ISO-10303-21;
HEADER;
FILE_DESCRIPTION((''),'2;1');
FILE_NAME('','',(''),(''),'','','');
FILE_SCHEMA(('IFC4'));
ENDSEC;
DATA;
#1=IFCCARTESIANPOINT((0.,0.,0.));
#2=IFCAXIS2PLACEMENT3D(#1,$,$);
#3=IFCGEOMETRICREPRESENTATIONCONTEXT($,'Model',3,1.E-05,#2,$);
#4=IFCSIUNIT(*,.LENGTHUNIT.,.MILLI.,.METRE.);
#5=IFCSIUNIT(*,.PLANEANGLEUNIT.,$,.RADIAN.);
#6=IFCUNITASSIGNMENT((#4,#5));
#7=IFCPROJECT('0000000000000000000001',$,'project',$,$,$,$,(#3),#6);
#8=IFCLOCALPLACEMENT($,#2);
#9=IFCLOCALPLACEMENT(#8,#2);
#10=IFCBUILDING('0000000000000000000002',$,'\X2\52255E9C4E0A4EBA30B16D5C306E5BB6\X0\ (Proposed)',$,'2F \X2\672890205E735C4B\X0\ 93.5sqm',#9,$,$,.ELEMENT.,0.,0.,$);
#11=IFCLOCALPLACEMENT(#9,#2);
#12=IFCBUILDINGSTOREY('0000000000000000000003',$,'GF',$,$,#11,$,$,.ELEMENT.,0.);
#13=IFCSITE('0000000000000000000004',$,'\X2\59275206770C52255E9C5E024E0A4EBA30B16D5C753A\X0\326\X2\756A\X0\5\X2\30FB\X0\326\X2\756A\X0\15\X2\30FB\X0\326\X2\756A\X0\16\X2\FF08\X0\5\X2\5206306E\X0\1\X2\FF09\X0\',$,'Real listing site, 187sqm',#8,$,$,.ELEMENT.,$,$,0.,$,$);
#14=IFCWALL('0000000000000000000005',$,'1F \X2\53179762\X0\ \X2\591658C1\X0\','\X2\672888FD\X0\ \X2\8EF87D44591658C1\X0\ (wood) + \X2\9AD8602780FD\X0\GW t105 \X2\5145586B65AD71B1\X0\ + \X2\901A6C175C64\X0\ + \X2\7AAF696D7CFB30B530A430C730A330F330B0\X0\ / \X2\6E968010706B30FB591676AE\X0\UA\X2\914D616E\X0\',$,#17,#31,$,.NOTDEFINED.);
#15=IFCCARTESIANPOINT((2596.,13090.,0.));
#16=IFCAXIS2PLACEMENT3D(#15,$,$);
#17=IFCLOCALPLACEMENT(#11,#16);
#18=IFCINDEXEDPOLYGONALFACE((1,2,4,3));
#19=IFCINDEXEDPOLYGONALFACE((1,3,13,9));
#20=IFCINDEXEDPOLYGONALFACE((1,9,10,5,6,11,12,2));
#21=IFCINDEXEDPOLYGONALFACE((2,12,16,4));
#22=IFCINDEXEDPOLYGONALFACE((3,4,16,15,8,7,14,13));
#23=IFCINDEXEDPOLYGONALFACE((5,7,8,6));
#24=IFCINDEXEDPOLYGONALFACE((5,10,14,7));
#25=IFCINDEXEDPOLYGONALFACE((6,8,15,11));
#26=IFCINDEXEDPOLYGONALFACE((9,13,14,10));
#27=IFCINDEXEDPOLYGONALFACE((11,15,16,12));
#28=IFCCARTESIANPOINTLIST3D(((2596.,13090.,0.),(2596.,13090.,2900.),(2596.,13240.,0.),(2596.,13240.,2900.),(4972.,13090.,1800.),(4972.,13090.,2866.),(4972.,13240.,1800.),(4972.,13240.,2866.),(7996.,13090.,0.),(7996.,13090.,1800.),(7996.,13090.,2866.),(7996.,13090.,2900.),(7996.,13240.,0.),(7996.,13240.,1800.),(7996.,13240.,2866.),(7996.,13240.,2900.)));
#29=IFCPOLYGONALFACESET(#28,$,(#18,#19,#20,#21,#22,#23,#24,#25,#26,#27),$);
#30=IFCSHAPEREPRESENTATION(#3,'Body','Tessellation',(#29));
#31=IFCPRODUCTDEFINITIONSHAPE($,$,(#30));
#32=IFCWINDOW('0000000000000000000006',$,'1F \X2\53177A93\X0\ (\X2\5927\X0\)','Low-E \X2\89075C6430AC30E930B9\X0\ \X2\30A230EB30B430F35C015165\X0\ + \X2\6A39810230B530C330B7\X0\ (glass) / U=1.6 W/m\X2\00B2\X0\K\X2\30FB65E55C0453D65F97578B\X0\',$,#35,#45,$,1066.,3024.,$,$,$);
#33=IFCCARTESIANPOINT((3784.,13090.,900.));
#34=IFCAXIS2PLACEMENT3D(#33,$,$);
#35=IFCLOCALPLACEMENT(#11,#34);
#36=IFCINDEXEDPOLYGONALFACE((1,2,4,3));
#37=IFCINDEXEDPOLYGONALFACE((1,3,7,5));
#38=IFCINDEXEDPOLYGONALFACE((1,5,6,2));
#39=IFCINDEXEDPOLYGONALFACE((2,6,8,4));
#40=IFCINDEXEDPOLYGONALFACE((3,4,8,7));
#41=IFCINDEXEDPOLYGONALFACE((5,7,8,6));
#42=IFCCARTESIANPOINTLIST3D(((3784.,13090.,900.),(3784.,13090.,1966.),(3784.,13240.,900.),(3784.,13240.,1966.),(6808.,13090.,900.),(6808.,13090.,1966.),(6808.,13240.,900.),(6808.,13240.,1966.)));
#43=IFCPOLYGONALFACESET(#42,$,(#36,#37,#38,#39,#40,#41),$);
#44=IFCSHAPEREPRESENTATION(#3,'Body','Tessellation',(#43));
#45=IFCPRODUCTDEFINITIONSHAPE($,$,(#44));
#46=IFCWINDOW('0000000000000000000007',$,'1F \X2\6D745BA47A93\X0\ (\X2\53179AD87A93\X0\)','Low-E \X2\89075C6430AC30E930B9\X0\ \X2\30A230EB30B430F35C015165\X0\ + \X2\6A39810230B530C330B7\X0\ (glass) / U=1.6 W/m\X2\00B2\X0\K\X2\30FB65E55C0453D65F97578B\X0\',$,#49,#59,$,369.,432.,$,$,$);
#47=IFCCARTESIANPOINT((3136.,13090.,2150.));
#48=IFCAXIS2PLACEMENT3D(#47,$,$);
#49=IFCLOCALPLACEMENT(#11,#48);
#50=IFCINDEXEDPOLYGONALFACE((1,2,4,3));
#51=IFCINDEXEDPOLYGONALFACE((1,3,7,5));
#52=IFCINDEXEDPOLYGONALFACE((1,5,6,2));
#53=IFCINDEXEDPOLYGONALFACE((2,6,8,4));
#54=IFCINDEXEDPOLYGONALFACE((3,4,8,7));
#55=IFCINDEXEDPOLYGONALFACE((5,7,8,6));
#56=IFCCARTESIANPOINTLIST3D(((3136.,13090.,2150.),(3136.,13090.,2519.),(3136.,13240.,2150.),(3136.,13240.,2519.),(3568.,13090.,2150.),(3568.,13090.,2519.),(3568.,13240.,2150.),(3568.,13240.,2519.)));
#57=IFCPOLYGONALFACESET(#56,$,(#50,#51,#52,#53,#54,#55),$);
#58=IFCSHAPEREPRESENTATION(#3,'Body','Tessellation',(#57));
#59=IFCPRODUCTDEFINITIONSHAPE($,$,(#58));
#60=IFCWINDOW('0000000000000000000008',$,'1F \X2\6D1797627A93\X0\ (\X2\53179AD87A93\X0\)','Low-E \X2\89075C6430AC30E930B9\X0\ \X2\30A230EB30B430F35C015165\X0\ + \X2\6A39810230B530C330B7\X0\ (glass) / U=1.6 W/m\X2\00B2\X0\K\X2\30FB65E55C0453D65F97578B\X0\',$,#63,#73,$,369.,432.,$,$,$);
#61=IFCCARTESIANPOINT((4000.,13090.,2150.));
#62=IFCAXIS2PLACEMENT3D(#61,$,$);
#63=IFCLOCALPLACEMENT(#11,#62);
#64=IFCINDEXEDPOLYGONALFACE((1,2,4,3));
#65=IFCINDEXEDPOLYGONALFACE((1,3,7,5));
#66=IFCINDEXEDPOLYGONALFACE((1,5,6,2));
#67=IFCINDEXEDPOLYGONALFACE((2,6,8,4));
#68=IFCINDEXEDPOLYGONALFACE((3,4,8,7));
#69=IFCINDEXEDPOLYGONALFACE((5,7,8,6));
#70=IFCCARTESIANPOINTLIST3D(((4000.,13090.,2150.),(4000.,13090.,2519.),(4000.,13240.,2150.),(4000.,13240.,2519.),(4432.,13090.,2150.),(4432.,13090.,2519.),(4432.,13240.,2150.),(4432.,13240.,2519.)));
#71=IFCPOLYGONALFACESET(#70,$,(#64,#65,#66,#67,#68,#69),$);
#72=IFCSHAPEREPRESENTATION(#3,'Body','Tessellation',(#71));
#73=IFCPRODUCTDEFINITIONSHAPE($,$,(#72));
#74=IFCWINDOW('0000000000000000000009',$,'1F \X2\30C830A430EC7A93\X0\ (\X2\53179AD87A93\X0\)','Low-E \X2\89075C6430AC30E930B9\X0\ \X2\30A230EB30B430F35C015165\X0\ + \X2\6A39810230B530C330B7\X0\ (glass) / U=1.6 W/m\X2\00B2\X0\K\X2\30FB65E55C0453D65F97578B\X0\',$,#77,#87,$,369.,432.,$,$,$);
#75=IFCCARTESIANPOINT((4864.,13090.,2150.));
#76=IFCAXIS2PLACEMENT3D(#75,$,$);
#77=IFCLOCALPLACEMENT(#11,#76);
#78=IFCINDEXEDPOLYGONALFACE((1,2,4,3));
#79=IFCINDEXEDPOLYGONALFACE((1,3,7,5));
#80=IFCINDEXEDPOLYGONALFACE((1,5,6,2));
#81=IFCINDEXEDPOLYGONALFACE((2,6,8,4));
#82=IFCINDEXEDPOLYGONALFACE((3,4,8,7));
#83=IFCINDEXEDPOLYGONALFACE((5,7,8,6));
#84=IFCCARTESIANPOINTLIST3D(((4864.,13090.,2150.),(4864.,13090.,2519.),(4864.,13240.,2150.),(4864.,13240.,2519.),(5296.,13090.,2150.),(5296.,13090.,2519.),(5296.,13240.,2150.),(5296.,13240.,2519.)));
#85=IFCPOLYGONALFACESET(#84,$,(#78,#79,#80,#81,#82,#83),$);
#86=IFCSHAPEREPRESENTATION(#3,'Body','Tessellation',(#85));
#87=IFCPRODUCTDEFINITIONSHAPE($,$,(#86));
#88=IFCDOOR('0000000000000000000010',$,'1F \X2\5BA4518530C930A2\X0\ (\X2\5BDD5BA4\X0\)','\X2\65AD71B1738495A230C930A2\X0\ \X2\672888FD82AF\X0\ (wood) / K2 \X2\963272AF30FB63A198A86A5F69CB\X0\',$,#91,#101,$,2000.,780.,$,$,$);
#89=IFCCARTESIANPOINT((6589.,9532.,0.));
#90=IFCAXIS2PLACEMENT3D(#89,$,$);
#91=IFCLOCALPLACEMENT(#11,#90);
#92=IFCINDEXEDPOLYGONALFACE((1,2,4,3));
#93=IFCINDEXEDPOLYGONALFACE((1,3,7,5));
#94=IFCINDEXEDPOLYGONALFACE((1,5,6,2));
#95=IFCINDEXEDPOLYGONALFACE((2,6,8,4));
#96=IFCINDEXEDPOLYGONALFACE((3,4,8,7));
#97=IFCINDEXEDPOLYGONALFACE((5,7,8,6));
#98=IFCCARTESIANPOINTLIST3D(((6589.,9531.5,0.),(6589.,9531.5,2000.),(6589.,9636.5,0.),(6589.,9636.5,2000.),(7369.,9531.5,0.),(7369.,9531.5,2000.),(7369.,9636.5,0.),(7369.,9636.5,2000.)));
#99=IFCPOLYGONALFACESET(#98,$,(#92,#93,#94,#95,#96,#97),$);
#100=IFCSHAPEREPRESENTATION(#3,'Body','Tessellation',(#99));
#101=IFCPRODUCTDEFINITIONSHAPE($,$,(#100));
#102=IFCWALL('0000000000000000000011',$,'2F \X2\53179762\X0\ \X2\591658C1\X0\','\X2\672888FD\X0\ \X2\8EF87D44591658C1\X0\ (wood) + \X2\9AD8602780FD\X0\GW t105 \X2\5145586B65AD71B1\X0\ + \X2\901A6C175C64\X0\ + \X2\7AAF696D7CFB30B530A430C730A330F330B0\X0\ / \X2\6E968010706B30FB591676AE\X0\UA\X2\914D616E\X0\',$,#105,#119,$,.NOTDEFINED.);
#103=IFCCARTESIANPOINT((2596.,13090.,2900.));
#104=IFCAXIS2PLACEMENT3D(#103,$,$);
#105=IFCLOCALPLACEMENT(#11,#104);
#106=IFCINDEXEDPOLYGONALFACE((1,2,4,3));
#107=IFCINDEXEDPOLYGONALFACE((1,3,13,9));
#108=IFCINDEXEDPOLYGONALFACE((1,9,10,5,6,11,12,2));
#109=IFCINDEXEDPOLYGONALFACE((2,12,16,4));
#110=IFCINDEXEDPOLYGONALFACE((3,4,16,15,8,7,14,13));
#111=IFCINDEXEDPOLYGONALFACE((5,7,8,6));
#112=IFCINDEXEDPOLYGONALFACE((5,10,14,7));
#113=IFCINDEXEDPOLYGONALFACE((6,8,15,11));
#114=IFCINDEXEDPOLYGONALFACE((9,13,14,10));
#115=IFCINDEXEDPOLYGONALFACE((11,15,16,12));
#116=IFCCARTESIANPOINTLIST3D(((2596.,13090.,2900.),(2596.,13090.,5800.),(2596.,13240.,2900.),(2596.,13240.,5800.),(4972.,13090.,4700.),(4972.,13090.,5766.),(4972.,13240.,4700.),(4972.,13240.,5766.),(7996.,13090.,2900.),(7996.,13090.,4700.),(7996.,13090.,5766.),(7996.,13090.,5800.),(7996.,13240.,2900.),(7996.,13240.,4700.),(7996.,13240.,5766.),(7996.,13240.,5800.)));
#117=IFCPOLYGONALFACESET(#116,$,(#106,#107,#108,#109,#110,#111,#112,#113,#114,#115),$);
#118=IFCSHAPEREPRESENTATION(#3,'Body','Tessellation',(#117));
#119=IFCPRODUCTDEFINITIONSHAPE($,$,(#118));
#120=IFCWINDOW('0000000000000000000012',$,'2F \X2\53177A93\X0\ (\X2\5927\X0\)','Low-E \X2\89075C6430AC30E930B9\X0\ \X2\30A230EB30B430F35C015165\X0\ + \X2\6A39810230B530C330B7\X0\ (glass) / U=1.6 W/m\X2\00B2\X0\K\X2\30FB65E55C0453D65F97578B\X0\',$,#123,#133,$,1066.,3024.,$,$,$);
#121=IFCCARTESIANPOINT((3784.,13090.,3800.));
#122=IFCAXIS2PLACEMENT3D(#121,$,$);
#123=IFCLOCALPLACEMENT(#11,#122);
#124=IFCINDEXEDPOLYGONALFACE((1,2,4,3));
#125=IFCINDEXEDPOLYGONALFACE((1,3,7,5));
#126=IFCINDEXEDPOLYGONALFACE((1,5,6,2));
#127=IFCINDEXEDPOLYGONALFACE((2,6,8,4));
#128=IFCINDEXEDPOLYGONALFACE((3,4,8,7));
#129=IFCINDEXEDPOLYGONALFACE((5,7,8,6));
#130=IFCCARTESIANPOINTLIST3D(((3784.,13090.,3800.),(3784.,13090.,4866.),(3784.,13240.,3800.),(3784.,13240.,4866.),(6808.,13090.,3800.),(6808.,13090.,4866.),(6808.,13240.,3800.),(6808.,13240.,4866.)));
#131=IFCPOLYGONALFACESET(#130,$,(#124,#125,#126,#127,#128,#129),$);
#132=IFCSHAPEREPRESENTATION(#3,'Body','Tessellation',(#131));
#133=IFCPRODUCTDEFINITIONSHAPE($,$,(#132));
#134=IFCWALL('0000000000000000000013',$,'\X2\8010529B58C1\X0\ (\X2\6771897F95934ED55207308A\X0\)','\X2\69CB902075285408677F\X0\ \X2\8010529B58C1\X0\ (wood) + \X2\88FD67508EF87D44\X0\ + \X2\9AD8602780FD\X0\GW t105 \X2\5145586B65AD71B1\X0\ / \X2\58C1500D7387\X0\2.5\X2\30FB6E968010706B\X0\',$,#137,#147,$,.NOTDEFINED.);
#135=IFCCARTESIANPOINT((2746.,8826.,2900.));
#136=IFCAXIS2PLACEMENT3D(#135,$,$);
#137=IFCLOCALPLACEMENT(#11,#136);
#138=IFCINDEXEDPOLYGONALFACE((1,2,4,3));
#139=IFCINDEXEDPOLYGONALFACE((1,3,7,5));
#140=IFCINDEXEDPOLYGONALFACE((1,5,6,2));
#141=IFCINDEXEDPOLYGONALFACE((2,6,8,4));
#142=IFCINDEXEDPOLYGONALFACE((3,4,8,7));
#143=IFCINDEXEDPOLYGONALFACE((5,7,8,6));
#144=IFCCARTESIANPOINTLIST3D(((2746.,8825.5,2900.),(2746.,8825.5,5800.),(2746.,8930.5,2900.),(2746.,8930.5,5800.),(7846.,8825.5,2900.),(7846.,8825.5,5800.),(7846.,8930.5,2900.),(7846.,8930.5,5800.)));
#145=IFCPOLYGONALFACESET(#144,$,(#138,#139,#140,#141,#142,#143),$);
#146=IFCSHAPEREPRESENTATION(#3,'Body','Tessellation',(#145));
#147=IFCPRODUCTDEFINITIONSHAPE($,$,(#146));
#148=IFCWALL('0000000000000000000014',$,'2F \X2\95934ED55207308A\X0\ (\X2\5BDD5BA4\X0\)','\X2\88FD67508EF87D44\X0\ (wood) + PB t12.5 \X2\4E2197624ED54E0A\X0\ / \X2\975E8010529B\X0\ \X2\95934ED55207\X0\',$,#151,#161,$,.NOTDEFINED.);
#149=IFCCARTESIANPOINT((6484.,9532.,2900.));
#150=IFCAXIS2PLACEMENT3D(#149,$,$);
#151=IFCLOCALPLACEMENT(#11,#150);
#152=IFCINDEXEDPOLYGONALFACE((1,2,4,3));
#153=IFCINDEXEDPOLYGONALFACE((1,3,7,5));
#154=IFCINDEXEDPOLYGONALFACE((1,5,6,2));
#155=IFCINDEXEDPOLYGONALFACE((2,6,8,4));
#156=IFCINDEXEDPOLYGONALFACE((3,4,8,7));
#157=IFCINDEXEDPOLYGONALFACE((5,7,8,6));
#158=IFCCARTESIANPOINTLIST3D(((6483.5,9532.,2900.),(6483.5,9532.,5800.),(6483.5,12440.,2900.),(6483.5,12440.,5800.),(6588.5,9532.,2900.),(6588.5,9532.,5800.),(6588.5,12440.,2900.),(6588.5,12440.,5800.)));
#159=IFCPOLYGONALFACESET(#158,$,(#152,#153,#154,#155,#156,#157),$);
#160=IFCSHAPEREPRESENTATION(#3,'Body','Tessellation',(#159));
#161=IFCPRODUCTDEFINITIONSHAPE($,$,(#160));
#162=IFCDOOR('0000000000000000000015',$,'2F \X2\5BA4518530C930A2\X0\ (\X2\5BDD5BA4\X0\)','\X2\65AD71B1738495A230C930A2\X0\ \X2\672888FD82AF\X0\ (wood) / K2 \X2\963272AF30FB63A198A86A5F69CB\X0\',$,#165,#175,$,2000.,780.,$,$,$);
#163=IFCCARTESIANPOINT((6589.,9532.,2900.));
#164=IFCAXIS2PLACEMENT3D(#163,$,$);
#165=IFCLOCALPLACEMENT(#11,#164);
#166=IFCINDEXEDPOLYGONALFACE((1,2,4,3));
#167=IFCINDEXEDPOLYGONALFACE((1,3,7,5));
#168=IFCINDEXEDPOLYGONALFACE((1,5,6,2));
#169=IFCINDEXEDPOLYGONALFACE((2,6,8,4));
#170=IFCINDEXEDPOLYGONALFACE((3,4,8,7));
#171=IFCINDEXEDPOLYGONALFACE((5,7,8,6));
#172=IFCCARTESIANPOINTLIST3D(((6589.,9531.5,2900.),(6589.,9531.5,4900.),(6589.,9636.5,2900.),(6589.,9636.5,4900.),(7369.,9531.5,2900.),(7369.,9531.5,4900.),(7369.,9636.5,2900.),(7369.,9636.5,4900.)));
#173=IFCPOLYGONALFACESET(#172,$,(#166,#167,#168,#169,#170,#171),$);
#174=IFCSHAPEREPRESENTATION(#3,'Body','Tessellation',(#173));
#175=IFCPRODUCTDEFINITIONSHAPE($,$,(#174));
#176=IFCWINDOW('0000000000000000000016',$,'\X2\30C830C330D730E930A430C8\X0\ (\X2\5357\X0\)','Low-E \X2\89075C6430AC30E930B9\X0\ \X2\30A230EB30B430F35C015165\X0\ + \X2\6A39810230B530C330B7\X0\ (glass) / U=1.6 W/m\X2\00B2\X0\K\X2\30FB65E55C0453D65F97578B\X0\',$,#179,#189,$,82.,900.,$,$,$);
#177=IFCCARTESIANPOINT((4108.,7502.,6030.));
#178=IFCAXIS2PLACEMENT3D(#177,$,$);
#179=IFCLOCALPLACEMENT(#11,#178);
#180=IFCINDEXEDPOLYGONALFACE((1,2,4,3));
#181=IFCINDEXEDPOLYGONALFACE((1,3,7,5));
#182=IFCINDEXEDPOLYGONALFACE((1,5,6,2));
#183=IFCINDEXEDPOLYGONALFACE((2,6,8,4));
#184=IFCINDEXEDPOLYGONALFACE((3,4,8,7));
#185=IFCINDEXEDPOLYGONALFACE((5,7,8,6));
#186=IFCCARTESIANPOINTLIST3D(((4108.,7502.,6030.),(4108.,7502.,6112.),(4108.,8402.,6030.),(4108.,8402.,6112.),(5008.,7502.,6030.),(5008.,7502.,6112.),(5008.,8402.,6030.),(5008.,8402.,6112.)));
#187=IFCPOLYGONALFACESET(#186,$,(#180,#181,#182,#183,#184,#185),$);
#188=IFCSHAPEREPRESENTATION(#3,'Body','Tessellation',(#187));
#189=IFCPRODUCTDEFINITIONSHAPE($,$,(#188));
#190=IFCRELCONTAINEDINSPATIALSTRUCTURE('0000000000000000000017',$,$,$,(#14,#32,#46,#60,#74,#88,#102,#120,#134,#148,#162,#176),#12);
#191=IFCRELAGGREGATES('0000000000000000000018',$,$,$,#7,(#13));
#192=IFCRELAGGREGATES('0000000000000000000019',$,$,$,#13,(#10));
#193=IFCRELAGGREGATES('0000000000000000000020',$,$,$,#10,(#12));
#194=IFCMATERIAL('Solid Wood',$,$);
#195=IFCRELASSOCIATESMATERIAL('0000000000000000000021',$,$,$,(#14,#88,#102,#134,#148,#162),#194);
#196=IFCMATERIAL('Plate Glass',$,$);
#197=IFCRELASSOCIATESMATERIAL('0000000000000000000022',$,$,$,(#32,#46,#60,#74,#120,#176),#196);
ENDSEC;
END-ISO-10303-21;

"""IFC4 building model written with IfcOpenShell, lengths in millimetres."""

from ifc_helpers import new_model, si_unit, frame, frame_2d, origin, place, context, project, spatial, rectangle, extrude, material, element, fill, save


model = new_model("IFC4")

# Units and contexts
model_context = context("Model", 3, precision=1e-05, world=origin())
ifc_project = project(units=[si_unit("LENGTHUNIT", "METRE", prefix="MILLI"), si_unit("PLANEANGLEUNIT", "RADIAN")], contexts=[model_context])

# Site, building, storey
site_placement = place(None, origin())
site = spatial("IfcSite", under=ifc_project, at=site_placement, Name="大分県別府市上人ケ浜町326番5・326番15・326番16（5分の1）", ObjectType="Real listing site, 187sqm", CompositionType="ELEMENT", RefElevation=0.0)
building_placement = place(site_placement, origin())
building = spatial("IfcBuilding", under=site, at=building_placement, Name="別府上人ケ浜の家 (Proposed)", ObjectType="2F 木造平屋 93.5sqm", CompositionType="ELEMENT", ElevationOfRefHeight=0.0, ElevationOfTerrain=0.0)
storey_placement = place(building_placement, origin())
storey = spatial("IfcBuildingStorey", under=building, at=storey_placement, Name="GF", CompositionType="ELEMENT", Elevation=0.0)

# Wall, openings, windows
ifc_material_1 = material(Name="Solid Wood")
wall_1_placement = place(storey_placement, frame((2596.0, 13090.0, 0.0)))
wall_1 = element("IfcWall", 1, at=wall_1_placement, inside=storey, material=ifc_material_1, Name="1F 北面 外壁", Description="木製 軸組外壁 (wood) + 高性能GW t105 充填断熱 + 通気層 + 窯業系サイディング / 準耐火・外皮UA配慮", PredefinedType="NOTDEFINED", context=model_context, shape_type="SweptSolid", body=[
    extrude(rectangle(XDim=5400.0, YDim=150.0, at=frame_2d((2700.0, 75.0))), frame((2596.0, 13090.0, 0.0)), (0.0, 0.0, 1.0), 2900.0),
])
opening_1_placement = place(storey_placement, frame((3784.0, 13090.0, 900.0)))
opening_1 = element("IfcOpeningElement", 2, at=opening_1_placement, cuts=wall_1, PredefinedType="NOTDEFINED", context=model_context, shape_type="SweptSolid", body=[
    extrude(rectangle(XDim=3024.0, YDim=150.0, at=frame_2d((1512.0, 75.0))), frame((3784.0, 13090.0, 900.0)), (0.0, 0.0, 1.0), 1066.0),
])
opening_2_placement = place(storey_placement, frame((3136.0, 13090.0, 2150.0)))
opening_2 = element("IfcOpeningElement", 3, at=opening_2_placement, cuts=wall_1, PredefinedType="NOTDEFINED", context=model_context, shape_type="SweptSolid", body=[
    extrude(rectangle(XDim=432.0, YDim=150.0, at=frame_2d((216.0, 75.0))), frame((3136.0, 13090.0, 2150.0)), (0.0, 0.0, 1.0), 369.0),
])
opening_3_placement = place(storey_placement, frame((4000.0, 13090.0, 2150.0)))
opening_3 = element("IfcOpeningElement", 4, at=opening_3_placement, cuts=wall_1, PredefinedType="NOTDEFINED", context=model_context, shape_type="SweptSolid", body=[
    extrude(rectangle(XDim=432.0, YDim=150.0, at=frame_2d((216.0, 75.0))), frame((4000.0, 13090.0, 2150.0)), (0.0, 0.0, 1.0), 369.0),
])
opening_4_placement = place(storey_placement, frame((4864.0, 13090.0, 2150.0)))
opening_4 = element("IfcOpeningElement", 5, at=opening_4_placement, cuts=wall_1, PredefinedType="NOTDEFINED", context=model_context, shape_type="SweptSolid", body=[
    extrude(rectangle(XDim=432.0, YDim=150.0, at=frame_2d((216.0, 75.0))), frame((4864.0, 13090.0, 2150.0)), (0.0, 0.0, 1.0), 369.0),
])
ifc_material_2 = material(Name="Plate Glass")
window_1_placement = place(storey_placement, frame((3784.0, 13090.0, 900.0)))
window_1 = element("IfcWindow", 6, at=window_1_placement, inside=storey, material=ifc_material_2, Name="1F 北窓 (大)", Description="Low-E 複層ガラス アルゴン封入 + 樹脂サッシ (glass) / U=1.6 W/m²K・日射取得型", OverallHeight=1066.0, OverallWidth=3024.0, context=model_context, shape_type="SweptSolid", body=[
    extrude(rectangle(XDim=3024.0, YDim=150.0, at=frame_2d((1512.0, 75.0))), frame((3784.0, 13090.0, 900.0)), (0.0, 0.0, 1.0), 1066.0),
])
fill(opening_1, window_1)
window_2_placement = place(storey_placement, frame((3136.0, 13090.0, 2150.0)))
window_2 = element("IfcWindow", 7, at=window_2_placement, inside=storey, material=ifc_material_2, Name="1F 浴室窓 (北高窓)", Description="Low-E 複層ガラス アルゴン封入 + 樹脂サッシ (glass) / U=1.6 W/m²K・日射取得型", OverallHeight=369.0, OverallWidth=432.0, context=model_context, shape_type="SweptSolid", body=[
    extrude(rectangle(XDim=432.0, YDim=150.0, at=frame_2d((216.0, 75.0))), frame((3136.0, 13090.0, 2150.0)), (0.0, 0.0, 1.0), 369.0),
])
fill(opening_2, window_2)
window_3_placement = place(storey_placement, frame((4000.0, 13090.0, 2150.0)))
window_3 = element("IfcWindow", 8, at=window_3_placement, inside=storey, material=ifc_material_2, Name="1F 洗面窓 (北高窓)", Description="Low-E 複層ガラス アルゴン封入 + 樹脂サッシ (glass) / U=1.6 W/m²K・日射取得型", OverallHeight=369.0, OverallWidth=432.0, context=model_context, shape_type="SweptSolid", body=[
    extrude(rectangle(XDim=432.0, YDim=150.0, at=frame_2d((216.0, 75.0))), frame((4000.0, 13090.0, 2150.0)), (0.0, 0.0, 1.0), 369.0),
])
fill(opening_3, window_3)
window_4_placement = place(storey_placement, frame((4864.0, 13090.0, 2150.0)))
window_4 = element("IfcWindow", 9, at=window_4_placement, inside=storey, material=ifc_material_2, Name="1F トイレ窓 (北高窓)", Description="Low-E 複層ガラス アルゴン封入 + 樹脂サッシ (glass) / U=1.6 W/m²K・日射取得型", OverallHeight=369.0, OverallWidth=432.0, context=model_context, shape_type="SweptSolid", body=[
    extrude(rectangle(XDim=432.0, YDim=150.0, at=frame_2d((216.0, 75.0))), frame((4864.0, 13090.0, 2150.0)), (0.0, 0.0, 1.0), 369.0),
])
fill(opening_4, window_4)

# Door
door_1_placement = place(storey_placement, frame((6589.0, 9532.0, 0.0)))
element("IfcDoor", 10, at=door_1_placement, inside=storey, material=ifc_material_1, Name="1F 室内ドア (寝室)", Description="断熱玄関ドア 木製芯 (wood) / K2 防犯・採風機構", OverallHeight=2000.0, OverallWidth=780.0, context=model_context, shape_type="SweptSolid", body=[
    extrude(rectangle(XDim=780.0, YDim=105.0, at=frame_2d((390.0, 52.0))), frame((6589.0, 9532.0, 0.0)), (0.0, 0.0, 1.0), 2000.0),
])

# Wall, opening, window
wall_2_placement = place(storey_placement, frame((2596.0, 13090.0, 2900.0)))
wall_2 = element("IfcWall", 11, at=wall_2_placement, inside=storey, material=ifc_material_1, Name="2F 北面 外壁", Description="木製 軸組外壁 (wood) + 高性能GW t105 充填断熱 + 通気層 + 窯業系サイディング / 準耐火・外皮UA配慮", PredefinedType="NOTDEFINED", context=model_context, shape_type="SweptSolid", body=[
    extrude(rectangle(XDim=5400.0, YDim=150.0, at=frame_2d((2700.0, 75.0))), frame((2596.0, 13090.0, 2900.0)), (0.0, 0.0, 1.0), 2900.0),
])
opening_5_placement = place(storey_placement, frame((3784.0, 13090.0, 3800.0)))
opening_5 = element("IfcOpeningElement", 12, at=opening_5_placement, cuts=wall_2, PredefinedType="NOTDEFINED", context=model_context, shape_type="SweptSolid", body=[
    extrude(rectangle(XDim=3024.0, YDim=150.0, at=frame_2d((1512.0, 75.0))), frame((3784.0, 13090.0, 3800.0)), (0.0, 0.0, 1.0), 1066.0),
])
window_5_placement = place(storey_placement, frame((3784.0, 13090.0, 3800.0)))
window_5 = element("IfcWindow", 13, at=window_5_placement, inside=storey, material=ifc_material_2, Name="2F 北窓 (大)", Description="Low-E 複層ガラス アルゴン封入 + 樹脂サッシ (glass) / U=1.6 W/m²K・日射取得型", OverallHeight=1066.0, OverallWidth=3024.0, context=model_context, shape_type="SweptSolid", body=[
    extrude(rectangle(XDim=3024.0, YDim=150.0, at=frame_2d((1512.0, 75.0))), frame((3784.0, 13090.0, 3800.0)), (0.0, 0.0, 1.0), 1066.0),
])
fill(opening_5, window_5)

# Walls
wall_3_placement = place(storey_placement, frame((2746.0, 8826.0, 2900.0)))
element("IfcWall", 14, at=wall_3_placement, inside=storey, material=ifc_material_1, Name="耐力壁 (東西間仕切り)", Description="構造用合板 耐力壁 (wood) + 製材軸組 + 高性能GW t105 充填断熱 / 壁倍率2.5・準耐火", PredefinedType="NOTDEFINED", context=model_context, shape_type="SweptSolid", body=[
    extrude(rectangle(XDim=5100.0, YDim=105.0, at=frame_2d((2550.0, 52.0))), frame((2746.0, 8826.0, 2900.0)), (0.0, 0.0, 1.0), 2900.0),
])
wall_4_placement = place(storey_placement, frame((6484.0, 9532.0, 2900.0)))
element("IfcWall", 15, at=wall_4_placement, inside=storey, material=ifc_material_1, Name="2F 間仕切り (寝室)", Description="製材軸組 (wood) + PB t12.5 両面仕上 / 非耐力 間仕切", PredefinedType="NOTDEFINED", context=model_context, shape_type="SweptSolid", body=[
    extrude(rectangle(XDim=105.0, YDim=2908.0, at=frame_2d((52.0, 1454.0))), frame((6484.0, 9532.0, 2900.0)), (0.0, 0.0, 1.0), 2900.0),
])

# Door
door_2_placement = place(storey_placement, frame((6589.0, 9532.0, 2900.0)))
element("IfcDoor", 16, at=door_2_placement, inside=storey, material=ifc_material_1, Name="2F 室内ドア (寝室)", Description="断熱玄関ドア 木製芯 (wood) / K2 防犯・採風機構", OverallHeight=2000.0, OverallWidth=780.0, context=model_context, shape_type="SweptSolid", body=[
    extrude(rectangle(XDim=780.0, YDim=105.0, at=frame_2d((390.0, 52.0))), frame((6589.0, 9532.0, 2900.0)), (0.0, 0.0, 1.0), 2000.0),
])

# Window
window_6_placement = place(storey_placement, frame((4108.0, 7502.0, 6030.0)))
element("IfcWindow", 17, at=window_6_placement, inside=storey, material=ifc_material_2, Name="トップライト (南)", Description="Low-E 複層ガラス アルゴン封入 + 樹脂サッシ (glass) / U=1.6 W/m²K・日射取得型", OverallHeight=82.0, OverallWidth=900.0, context=model_context, shape_type="SweptSolid", body=[
    extrude(rectangle(XDim=900.0, YDim=900.0, at=frame_2d((450.0, 450.0))), frame((4108.0, 7502.0, 6030.0)), (0.0, 0.0, 1.0), 82.0),
])

save(model, "model.ifc")
